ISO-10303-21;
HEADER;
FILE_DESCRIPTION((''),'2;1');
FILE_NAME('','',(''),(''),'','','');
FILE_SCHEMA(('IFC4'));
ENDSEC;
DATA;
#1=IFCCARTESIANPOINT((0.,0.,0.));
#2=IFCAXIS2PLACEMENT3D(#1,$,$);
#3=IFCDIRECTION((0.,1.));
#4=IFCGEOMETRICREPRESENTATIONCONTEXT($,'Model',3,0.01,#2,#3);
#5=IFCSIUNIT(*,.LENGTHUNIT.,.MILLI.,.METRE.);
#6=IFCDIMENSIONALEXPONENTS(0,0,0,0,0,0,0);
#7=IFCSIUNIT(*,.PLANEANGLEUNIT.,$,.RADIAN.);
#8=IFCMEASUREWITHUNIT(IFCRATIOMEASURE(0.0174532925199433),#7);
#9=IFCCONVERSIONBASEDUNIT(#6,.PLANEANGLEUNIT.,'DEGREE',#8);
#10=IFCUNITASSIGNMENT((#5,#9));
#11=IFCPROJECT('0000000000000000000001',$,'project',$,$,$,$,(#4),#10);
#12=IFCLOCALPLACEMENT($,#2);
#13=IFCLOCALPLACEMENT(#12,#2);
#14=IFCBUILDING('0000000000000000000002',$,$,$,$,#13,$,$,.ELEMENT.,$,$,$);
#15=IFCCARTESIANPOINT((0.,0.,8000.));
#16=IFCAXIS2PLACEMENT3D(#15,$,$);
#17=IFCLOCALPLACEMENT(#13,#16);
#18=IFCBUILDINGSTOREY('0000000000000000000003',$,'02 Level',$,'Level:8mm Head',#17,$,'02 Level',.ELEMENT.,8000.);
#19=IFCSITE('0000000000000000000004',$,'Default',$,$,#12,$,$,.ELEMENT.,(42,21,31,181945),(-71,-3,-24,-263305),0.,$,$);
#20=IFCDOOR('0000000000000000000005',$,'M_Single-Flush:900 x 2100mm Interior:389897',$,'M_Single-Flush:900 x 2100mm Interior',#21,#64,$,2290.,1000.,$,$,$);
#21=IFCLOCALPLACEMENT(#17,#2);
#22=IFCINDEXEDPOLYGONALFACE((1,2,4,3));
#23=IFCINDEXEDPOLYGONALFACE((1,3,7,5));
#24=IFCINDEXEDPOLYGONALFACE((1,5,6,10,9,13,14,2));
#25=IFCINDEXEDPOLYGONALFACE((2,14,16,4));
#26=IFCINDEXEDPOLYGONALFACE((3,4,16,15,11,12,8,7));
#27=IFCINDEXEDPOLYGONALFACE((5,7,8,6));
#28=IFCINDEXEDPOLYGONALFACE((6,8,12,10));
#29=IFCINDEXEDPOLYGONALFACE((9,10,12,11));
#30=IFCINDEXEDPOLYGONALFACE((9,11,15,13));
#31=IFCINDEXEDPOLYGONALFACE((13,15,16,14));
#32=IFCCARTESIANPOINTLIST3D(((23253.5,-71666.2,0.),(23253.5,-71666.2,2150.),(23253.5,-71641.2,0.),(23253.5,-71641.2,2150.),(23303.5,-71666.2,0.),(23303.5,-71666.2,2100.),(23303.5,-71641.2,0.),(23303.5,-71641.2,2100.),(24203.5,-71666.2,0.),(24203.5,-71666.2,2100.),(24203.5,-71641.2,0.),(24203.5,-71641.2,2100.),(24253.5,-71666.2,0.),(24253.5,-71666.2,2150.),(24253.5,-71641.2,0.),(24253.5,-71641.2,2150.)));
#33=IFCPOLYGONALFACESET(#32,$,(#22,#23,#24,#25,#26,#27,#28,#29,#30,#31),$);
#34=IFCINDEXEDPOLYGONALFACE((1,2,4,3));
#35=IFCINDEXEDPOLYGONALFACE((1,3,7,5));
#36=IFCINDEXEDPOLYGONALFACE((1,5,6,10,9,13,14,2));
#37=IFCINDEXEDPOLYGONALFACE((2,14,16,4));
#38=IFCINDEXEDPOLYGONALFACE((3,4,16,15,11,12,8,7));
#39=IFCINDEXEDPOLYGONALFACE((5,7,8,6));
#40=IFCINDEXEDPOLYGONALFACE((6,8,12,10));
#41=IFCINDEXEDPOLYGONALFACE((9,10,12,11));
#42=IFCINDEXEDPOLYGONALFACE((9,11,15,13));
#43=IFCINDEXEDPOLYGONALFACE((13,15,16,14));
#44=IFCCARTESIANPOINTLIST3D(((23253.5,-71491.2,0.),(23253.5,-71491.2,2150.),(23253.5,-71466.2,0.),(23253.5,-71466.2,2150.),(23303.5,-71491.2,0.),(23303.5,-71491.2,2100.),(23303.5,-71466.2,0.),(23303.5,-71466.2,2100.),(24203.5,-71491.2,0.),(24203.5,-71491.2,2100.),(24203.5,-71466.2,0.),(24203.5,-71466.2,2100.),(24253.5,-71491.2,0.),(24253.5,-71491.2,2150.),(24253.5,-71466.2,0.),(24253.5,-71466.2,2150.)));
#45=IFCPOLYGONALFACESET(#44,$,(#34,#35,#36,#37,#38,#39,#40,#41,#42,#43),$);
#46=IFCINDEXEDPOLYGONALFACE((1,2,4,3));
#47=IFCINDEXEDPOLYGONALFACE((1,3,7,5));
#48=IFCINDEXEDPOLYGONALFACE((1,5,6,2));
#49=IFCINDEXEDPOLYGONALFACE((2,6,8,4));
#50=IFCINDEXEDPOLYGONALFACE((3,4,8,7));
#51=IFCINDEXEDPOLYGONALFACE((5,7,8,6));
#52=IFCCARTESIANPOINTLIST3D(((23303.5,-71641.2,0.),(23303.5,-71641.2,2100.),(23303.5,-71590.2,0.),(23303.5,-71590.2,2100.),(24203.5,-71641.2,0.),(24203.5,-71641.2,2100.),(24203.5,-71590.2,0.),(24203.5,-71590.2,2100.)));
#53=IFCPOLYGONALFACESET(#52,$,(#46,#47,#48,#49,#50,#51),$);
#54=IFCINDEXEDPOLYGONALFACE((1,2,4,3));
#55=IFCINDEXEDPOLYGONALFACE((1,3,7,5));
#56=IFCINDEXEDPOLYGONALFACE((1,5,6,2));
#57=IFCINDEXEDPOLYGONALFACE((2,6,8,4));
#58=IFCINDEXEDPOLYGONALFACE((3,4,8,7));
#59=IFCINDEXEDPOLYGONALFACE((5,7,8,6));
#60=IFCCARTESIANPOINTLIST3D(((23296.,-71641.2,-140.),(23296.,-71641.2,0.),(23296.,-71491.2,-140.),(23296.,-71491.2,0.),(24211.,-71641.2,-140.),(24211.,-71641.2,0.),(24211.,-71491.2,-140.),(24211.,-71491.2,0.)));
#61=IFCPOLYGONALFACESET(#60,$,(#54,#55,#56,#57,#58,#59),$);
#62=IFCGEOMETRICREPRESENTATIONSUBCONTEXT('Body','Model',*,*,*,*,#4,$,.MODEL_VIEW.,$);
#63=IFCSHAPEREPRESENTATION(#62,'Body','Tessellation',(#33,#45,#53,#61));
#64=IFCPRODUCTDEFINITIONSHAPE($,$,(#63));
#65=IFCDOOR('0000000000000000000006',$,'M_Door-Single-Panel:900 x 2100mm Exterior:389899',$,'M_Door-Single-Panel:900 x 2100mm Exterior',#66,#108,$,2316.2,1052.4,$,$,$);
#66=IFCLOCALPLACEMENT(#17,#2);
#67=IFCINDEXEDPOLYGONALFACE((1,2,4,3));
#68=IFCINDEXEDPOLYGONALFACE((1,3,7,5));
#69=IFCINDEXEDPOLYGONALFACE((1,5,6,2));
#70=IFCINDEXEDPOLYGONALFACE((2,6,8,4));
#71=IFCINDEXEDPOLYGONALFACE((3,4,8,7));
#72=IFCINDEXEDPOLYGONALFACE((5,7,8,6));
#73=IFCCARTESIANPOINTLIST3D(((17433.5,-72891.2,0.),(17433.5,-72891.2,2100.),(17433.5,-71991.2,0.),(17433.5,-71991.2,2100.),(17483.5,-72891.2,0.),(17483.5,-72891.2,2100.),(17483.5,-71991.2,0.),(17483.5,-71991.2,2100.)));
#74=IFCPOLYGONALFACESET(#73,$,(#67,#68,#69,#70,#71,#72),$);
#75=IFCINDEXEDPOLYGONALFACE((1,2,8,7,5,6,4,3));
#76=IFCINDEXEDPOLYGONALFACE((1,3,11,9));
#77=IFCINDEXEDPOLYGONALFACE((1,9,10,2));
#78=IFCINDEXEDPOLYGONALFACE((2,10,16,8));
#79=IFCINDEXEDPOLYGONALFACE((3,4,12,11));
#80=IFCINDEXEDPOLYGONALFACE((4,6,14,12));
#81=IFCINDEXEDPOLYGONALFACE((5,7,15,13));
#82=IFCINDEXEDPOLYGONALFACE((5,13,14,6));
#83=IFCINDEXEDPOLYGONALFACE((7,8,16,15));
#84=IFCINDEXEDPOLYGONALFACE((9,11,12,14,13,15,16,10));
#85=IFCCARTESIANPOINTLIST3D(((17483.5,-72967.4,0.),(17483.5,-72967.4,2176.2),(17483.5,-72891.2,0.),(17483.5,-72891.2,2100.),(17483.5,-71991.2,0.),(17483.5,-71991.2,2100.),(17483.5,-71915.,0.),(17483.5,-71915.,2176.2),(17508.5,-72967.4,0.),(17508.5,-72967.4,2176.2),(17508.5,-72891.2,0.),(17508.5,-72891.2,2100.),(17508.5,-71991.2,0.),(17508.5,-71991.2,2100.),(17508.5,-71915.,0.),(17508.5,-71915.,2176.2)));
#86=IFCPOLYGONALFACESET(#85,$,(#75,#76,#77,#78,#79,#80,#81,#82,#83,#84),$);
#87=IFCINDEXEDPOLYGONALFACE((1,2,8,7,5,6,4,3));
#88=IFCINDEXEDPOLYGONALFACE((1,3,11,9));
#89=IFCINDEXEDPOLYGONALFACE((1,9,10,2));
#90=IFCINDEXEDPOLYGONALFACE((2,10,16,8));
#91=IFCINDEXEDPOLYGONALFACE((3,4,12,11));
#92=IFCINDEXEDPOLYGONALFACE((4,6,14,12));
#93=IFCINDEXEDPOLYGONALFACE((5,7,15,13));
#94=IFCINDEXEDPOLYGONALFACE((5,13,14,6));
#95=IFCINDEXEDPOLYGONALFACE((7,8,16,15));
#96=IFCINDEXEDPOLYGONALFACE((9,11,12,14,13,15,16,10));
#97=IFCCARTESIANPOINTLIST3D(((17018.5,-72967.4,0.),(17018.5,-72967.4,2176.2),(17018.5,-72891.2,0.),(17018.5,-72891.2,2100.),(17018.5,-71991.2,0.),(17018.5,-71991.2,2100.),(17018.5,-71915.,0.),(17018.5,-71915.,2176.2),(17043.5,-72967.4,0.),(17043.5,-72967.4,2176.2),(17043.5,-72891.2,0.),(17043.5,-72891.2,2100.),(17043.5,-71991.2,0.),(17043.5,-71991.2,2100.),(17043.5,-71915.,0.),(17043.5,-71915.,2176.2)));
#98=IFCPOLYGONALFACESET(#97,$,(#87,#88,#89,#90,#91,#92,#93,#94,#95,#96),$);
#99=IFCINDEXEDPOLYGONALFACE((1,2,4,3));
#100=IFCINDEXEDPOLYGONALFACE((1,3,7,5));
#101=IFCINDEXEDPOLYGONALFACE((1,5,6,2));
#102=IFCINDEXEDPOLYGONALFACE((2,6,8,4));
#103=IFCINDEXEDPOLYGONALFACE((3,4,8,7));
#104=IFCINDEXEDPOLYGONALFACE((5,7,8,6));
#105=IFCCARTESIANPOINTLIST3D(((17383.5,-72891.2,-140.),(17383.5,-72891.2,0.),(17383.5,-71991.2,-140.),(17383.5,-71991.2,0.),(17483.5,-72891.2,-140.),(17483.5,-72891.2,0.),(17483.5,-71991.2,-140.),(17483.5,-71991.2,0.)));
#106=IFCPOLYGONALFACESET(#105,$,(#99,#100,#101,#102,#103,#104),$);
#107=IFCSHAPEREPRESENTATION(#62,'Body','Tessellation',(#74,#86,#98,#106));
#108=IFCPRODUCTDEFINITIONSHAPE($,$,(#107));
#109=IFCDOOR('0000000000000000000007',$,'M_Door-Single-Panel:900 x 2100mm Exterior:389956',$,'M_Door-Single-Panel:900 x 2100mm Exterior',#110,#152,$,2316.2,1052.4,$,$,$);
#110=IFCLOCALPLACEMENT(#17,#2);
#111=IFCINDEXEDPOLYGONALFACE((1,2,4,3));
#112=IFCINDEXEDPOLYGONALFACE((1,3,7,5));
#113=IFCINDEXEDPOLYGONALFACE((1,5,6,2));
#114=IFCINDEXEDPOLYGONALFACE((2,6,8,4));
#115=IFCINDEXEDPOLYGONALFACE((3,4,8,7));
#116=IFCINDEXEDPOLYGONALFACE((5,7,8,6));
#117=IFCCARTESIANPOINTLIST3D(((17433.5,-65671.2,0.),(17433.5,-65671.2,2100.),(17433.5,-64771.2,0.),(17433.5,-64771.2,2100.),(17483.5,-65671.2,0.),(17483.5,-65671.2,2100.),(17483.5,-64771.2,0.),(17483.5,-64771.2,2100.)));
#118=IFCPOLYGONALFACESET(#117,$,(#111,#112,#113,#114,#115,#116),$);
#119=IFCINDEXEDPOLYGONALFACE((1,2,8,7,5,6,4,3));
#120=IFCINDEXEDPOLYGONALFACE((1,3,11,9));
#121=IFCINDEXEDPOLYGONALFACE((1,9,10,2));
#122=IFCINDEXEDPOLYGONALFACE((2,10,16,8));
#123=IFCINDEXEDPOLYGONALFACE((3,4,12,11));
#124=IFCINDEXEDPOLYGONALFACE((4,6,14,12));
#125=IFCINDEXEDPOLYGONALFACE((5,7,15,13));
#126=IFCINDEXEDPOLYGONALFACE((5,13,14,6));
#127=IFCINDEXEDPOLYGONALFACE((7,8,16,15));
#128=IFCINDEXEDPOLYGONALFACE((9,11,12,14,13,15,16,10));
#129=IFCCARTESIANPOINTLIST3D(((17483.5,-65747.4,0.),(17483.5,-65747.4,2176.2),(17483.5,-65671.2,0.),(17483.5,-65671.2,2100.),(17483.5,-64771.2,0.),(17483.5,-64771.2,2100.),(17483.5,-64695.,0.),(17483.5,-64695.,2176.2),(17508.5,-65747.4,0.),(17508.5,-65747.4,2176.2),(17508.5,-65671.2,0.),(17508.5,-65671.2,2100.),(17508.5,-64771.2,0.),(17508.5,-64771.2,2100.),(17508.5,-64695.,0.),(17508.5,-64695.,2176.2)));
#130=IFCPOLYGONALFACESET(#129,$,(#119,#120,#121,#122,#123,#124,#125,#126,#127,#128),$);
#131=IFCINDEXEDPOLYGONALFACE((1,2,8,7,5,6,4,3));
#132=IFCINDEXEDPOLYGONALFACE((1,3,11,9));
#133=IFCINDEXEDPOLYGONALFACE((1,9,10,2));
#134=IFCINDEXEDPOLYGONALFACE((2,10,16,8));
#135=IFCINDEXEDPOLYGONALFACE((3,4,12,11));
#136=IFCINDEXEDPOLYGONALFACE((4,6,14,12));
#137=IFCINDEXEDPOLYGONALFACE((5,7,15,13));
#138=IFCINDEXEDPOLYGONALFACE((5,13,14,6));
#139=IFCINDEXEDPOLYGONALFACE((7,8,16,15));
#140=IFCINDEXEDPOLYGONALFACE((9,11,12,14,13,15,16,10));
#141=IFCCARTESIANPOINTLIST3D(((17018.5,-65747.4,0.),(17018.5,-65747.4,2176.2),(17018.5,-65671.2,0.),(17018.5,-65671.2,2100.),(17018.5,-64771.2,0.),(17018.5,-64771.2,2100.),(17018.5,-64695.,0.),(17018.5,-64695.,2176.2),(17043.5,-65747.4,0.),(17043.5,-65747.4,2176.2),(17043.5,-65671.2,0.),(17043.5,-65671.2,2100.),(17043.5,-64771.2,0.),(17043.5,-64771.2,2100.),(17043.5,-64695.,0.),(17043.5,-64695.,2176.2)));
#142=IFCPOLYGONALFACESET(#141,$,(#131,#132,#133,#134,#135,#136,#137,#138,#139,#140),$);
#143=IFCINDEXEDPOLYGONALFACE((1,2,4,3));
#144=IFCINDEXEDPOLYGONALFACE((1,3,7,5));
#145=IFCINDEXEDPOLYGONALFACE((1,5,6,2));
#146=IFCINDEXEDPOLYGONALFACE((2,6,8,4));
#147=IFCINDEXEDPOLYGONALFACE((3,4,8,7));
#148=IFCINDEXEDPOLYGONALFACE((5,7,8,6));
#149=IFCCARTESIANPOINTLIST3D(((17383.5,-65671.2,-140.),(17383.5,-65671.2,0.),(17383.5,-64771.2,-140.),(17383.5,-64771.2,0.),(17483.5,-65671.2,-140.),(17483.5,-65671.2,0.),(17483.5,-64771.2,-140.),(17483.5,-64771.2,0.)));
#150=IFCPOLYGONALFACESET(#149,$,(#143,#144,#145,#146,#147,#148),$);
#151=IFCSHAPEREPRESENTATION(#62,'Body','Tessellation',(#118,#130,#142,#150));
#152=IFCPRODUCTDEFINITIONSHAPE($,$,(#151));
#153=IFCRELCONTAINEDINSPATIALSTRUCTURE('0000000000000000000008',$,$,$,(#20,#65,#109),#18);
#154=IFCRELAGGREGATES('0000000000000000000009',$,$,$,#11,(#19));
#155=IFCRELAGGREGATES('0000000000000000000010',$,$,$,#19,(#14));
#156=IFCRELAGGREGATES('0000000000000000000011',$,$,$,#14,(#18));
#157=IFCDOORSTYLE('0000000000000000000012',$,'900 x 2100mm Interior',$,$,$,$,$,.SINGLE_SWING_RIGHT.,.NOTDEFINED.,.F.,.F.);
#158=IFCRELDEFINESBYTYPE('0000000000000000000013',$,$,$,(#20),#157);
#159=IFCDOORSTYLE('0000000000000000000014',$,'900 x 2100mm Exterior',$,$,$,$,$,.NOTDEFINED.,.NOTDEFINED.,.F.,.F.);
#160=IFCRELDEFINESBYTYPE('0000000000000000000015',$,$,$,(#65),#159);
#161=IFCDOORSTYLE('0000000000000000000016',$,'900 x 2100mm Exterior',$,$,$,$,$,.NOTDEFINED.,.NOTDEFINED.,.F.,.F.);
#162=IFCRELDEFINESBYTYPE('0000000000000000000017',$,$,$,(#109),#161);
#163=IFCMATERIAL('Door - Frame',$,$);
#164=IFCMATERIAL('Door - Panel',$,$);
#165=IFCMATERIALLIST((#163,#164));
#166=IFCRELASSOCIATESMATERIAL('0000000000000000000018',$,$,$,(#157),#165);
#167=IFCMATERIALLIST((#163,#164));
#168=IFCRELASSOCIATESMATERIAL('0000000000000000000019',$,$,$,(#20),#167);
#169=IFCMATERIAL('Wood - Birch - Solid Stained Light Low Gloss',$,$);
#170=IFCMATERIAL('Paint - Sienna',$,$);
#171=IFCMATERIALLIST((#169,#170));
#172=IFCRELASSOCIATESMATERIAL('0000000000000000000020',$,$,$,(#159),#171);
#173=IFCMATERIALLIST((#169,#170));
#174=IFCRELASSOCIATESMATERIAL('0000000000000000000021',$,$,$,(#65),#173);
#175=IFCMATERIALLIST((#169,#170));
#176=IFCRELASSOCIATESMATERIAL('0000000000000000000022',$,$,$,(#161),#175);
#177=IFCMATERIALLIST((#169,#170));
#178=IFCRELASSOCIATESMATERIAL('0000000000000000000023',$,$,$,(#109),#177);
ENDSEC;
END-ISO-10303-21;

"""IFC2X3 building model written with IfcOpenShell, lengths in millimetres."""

from ifc_helpers import new_model, entity, si_unit, converted_unit, direction, frame, frame_2d, origin, origin_2d_with_axis, place, context, subcontext, project, spatial, polyline, rectangle, outline, extrude, source, transform, mapped, material, material_list, type_object, type_shapes, element, save


model = new_model("IFC2X3")

# Units and contexts
model_context = context("Model", 3, precision=0.01, world=origin(), true_north=direction((0.0, 1.0)))
body_context = subcontext(model_context, "Body", "Model", "MODEL_VIEW")
ifc_project = project(units=[si_unit("LENGTHUNIT", "METRE", prefix="MILLI"), converted_unit("PLANEANGLEUNIT", "DEGREE", entity("IfcRatioMeasure", 0.0174532925199433), si_unit("PLANEANGLEUNIT", "RADIAN"), dimensions=[0, 0, 0, 0, 0, 0, 0])], contexts=[model_context])

# Site, building, storey
site_placement = place(None, origin())
site = spatial("IfcSite", under=ifc_project, at=site_placement, Name="Default", CompositionType="ELEMENT", RefLatitude=(42, 21, 31, 181945), RefLongitude=(-71, -3, -24, -263305), RefElevation=0.0)
building_placement = place(site_placement, origin())
building = spatial("IfcBuilding", under=site, at=building_placement, CompositionType="ELEMENT")
storey_placement = place(building_placement, frame((0.0, 0.0, 8000.0)))
storey = spatial("IfcBuildingStorey", under=building, at=storey_placement, Name="02 Level", ObjectType="Level:8mm Head", LongName="02 Level", CompositionType="ELEMENT", Elevation=8000.0)

# Doors
ifc_material_1 = material(Name="Door - Frame")
ifc_material_2 = material(Name="Door - Panel")
ifc_material_list_1 = material_list([ifc_material_1, ifc_material_2])
ifc_material_list_2 = material_list([ifc_material_1, ifc_material_2])
door_style_1 = type_object("IfcDoorStyle", Name="900 x 2100mm Interior", ConstructionType="NOTDEFINED", OperationType="SINGLE_SWING_RIGHT", ParameterTakesPrecedence=False, Sizeable=False, material=ifc_material_list_2)
shared_shape_1 = source(origin(), body_context, "Body", "SweptSolid", [
    extrude(outline(polyline([(-500.0, -1087.5), (500.0, -1087.5), (500.0, 1062.5), (450.0, 1062.5), (450.0, -1037.5), (-450.0, -1037.5), (-450.0, 1062.5), (-500.0, 1062.5), (-500.0, -1087.5)])), frame((450.0, 150.0, 1202.5), z_axis=(0.0, 1.0, 0.0), x_axis=(1.0, 0.0, 0.0)), (0.0, 0.0, 1.0), 25.0),
    extrude(outline(polyline([(-1087.5, -500.0), (1062.5, -500.0), (1062.5, -450.0), (-1037.5, -450.0), (-1037.5, 450.0), (1062.5, 450.0), (1062.5, 500.0), (-1087.5, 500.0), (-1087.5, -500.0)])), frame((450.0, -25.0, 1202.5), z_axis=(0.0, 1.0, 0.0), x_axis=(0.0, 0.0, -1.0)), (0.0, 0.0, 1.0), 25.0),
    extrude(rectangle(XDim=51.0, YDim=900.0, at=frame_2d((0.0, 0.0), x_axis=(1.0, 0.0))), frame((450.0, 124.5, 140.0), z_axis=(0.0, 0.0, 1.0), x_axis=(0.0, 1.0, 0.0)), (0.0, 0.0, 1.0), 2100.0),
    extrude(rectangle(XDim=915.0, YDim=150.0, at=origin_2d_with_axis()), frame((450.0, 75.0, 0.0), z_axis=(0.0, 0.0, 1.0), x_axis=(-1.0, 0.0, 0.0)), (0.0, 0.0, 1.0), 140.0),
])
type_shapes(door_style_1, [shared_shape_1])
door_1_placement = place(storey_placement, frame((24203.5, -71491.2, -140.0), z_axis=(0.0, 0.0, 1.0), x_axis=(-1.0, 0.0, 0.0)))
element("IfcDoor", 1, at=door_1_placement, inside=storey, type_object=door_style_1, material=ifc_material_list_1, Name="M_Single-Flush:900 x 2100mm Interior:389897", ObjectType="M_Single-Flush:900 x 2100mm Interior", OverallHeight=2290.0, OverallWidth=1000.0, context=body_context, shape_type="MappedRepresentation", body=[
    mapped(shared_shape_1, transform((0.0, 0.0, 0.0), scale=1.0)),
])
ifc_material_3 = material(Name="Wood - Birch - Solid Stained Light Low Gloss")
ifc_material_4 = material(Name="Paint - Sienna")
ifc_material_list_3 = material_list([ifc_material_3, ifc_material_4])
ifc_material_list_4 = material_list([ifc_material_3, ifc_material_4])
door_style_2 = type_object("IfcDoorStyle", Name="900 x 2100mm Exterior", ConstructionType="NOTDEFINED", OperationType="NOTDEFINED", ParameterTakesPrecedence=False, Sizeable=False, material=ifc_material_list_4)
shared_shape_2 = source(origin(), body_context, "Body", "SweptSolid", [
    extrude(rectangle(XDim=50.0, YDim=900.0, at=origin_2d_with_axis()), frame((450.0, 415.0, 140.0), z_axis=(0.0, 0.0, 1.0), x_axis=(0.0, 1.0, 0.0)), (0.0, 0.0, 1.0), 2100.0),
    extrude(outline(polyline([(-526.2, -1107.2), (526.2, -1107.2), (526.2, 1069.0), (450.0, 1069.0), (450.0, -1031.0), (-450.0, -1031.0), (-450.0, 1069.0), (-526.2, 1069.0), (-526.2, -1107.2)])), frame((450.0, 440.0, 1209.0), z_axis=(0.0, 1.0, 0.0), x_axis=(1.0, 0.0, 0.0)), (0.0, 0.0, 1.0), 25.0),
    extrude(outline(polyline([(-1107.2, -526.2), (1069.0, -526.2), (1069.0, -450.0), (-1031.0, -450.0), (-1031.0, 450.0), (1069.0, 450.0), (1069.0, 526.2), (-1107.2, 526.2), (-1107.2, -526.2)])), frame((450.0, -25.0, 1209.0), z_axis=(0.0, 1.0, 0.0), x_axis=(0.0, 0.0, -1.0)), (0.0, 0.0, 1.0), 25.0),
    extrude(rectangle(XDim=900.0, YDim=100.0, at=origin_2d_with_axis()), frame((450.0, 390.0, 0.0), z_axis=(0.0, 0.0, 1.0), x_axis=(-1.0, 0.0, 0.0)), (0.0, 0.0, 1.0), 140.0),
])
type_shapes(door_style_2, [shared_shape_2])
door_2_placement = place(storey_placement, frame((17043.5, -71991.2, -140.0), z_axis=(0.0, 0.0, 1.0), x_axis=(0.0, -1.0, 0.0)))
element("IfcDoor", 2, at=door_2_placement, inside=storey, type_object=door_style_2, material=ifc_material_list_3, Name="M_Door-Single-Panel:900 x 2100mm Exterior:389899", ObjectType="M_Door-Single-Panel:900 x 2100mm Exterior", OverallHeight=2316.2, OverallWidth=1052.4, context=body_context, shape_type="MappedRepresentation", body=[
    mapped(shared_shape_2, transform((0.0, 0.0, 0.0), scale=1.0)),
])
ifc_material_list_5 = material_list([ifc_material_3, ifc_material_4])
ifc_material_list_6 = material_list([ifc_material_3, ifc_material_4])
door_style_3 = type_object("IfcDoorStyle", Name="900 x 2100mm Exterior", ConstructionType="NOTDEFINED", OperationType="NOTDEFINED", ParameterTakesPrecedence=False, Sizeable=False, material=ifc_material_list_6)
shared_shape_3 = source(origin(), body_context, "Body", "SweptSolid", [
    extrude(rectangle(XDim=900.0, YDim=50.0, at=origin_2d_with_axis()), frame((450.0, 415.0, 140.0)), (0.0, 0.0, 1.0), 2100.0),
    extrude(outline(polyline([(-526.2, -1107.2), (526.2, -1107.2), (526.2, 1069.0), (450.0, 1069.0), (450.0, -1031.0), (-450.0, -1031.0), (-450.0, 1069.0), (-526.2, 1069.0), (-526.2, -1107.2)])), frame((450.0, 465.0, 1209.0), z_axis=(0.0, -1.0, 0.0), x_axis=(-1.0, 0.0, 0.0)), (0.0, 0.0, 1.0), 25.0),
    extrude(outline(polyline([(-1107.2, -526.2), (1069.0, -526.2), (1069.0, -450.0), (-1031.0, -450.0), (-1031.0, 450.0), (1069.0, 450.0), (1069.0, 526.2), (-1107.2, 526.2), (-1107.2, -526.2)])), frame((450.0, 0.0, 1209.0), z_axis=(0.0, -1.0, 0.0), x_axis=(0.0, 0.0, -1.0)), (0.0, 0.0, 1.0), 25.0),
    extrude(rectangle(XDim=100.0, YDim=900.0, at=origin_2d_with_axis()), frame((450.0, 390.0, 0.0), z_axis=(0.0, 0.0, 1.0), x_axis=(0.0, -1.0, 0.0)), (0.0, 0.0, 1.0), 140.0),
])
type_shapes(door_style_3, [shared_shape_3])
door_3_placement = place(storey_placement, frame((17043.5, -64771.2, -140.0), z_axis=(0.0, 0.0, 1.0), x_axis=(0.0, -1.0, 0.0)))
element("IfcDoor", 3, at=door_3_placement, inside=storey, type_object=door_style_3, material=ifc_material_list_5, Name="M_Door-Single-Panel:900 x 2100mm Exterior:389956", ObjectType="M_Door-Single-Panel:900 x 2100mm Exterior", OverallHeight=2316.2, OverallWidth=1052.4, context=body_context, shape_type="MappedRepresentation", body=[
    mapped(shared_shape_3, transform((0.0, 0.0, 0.0), scale=1.0)),
])

save(model, "model.ifc")
